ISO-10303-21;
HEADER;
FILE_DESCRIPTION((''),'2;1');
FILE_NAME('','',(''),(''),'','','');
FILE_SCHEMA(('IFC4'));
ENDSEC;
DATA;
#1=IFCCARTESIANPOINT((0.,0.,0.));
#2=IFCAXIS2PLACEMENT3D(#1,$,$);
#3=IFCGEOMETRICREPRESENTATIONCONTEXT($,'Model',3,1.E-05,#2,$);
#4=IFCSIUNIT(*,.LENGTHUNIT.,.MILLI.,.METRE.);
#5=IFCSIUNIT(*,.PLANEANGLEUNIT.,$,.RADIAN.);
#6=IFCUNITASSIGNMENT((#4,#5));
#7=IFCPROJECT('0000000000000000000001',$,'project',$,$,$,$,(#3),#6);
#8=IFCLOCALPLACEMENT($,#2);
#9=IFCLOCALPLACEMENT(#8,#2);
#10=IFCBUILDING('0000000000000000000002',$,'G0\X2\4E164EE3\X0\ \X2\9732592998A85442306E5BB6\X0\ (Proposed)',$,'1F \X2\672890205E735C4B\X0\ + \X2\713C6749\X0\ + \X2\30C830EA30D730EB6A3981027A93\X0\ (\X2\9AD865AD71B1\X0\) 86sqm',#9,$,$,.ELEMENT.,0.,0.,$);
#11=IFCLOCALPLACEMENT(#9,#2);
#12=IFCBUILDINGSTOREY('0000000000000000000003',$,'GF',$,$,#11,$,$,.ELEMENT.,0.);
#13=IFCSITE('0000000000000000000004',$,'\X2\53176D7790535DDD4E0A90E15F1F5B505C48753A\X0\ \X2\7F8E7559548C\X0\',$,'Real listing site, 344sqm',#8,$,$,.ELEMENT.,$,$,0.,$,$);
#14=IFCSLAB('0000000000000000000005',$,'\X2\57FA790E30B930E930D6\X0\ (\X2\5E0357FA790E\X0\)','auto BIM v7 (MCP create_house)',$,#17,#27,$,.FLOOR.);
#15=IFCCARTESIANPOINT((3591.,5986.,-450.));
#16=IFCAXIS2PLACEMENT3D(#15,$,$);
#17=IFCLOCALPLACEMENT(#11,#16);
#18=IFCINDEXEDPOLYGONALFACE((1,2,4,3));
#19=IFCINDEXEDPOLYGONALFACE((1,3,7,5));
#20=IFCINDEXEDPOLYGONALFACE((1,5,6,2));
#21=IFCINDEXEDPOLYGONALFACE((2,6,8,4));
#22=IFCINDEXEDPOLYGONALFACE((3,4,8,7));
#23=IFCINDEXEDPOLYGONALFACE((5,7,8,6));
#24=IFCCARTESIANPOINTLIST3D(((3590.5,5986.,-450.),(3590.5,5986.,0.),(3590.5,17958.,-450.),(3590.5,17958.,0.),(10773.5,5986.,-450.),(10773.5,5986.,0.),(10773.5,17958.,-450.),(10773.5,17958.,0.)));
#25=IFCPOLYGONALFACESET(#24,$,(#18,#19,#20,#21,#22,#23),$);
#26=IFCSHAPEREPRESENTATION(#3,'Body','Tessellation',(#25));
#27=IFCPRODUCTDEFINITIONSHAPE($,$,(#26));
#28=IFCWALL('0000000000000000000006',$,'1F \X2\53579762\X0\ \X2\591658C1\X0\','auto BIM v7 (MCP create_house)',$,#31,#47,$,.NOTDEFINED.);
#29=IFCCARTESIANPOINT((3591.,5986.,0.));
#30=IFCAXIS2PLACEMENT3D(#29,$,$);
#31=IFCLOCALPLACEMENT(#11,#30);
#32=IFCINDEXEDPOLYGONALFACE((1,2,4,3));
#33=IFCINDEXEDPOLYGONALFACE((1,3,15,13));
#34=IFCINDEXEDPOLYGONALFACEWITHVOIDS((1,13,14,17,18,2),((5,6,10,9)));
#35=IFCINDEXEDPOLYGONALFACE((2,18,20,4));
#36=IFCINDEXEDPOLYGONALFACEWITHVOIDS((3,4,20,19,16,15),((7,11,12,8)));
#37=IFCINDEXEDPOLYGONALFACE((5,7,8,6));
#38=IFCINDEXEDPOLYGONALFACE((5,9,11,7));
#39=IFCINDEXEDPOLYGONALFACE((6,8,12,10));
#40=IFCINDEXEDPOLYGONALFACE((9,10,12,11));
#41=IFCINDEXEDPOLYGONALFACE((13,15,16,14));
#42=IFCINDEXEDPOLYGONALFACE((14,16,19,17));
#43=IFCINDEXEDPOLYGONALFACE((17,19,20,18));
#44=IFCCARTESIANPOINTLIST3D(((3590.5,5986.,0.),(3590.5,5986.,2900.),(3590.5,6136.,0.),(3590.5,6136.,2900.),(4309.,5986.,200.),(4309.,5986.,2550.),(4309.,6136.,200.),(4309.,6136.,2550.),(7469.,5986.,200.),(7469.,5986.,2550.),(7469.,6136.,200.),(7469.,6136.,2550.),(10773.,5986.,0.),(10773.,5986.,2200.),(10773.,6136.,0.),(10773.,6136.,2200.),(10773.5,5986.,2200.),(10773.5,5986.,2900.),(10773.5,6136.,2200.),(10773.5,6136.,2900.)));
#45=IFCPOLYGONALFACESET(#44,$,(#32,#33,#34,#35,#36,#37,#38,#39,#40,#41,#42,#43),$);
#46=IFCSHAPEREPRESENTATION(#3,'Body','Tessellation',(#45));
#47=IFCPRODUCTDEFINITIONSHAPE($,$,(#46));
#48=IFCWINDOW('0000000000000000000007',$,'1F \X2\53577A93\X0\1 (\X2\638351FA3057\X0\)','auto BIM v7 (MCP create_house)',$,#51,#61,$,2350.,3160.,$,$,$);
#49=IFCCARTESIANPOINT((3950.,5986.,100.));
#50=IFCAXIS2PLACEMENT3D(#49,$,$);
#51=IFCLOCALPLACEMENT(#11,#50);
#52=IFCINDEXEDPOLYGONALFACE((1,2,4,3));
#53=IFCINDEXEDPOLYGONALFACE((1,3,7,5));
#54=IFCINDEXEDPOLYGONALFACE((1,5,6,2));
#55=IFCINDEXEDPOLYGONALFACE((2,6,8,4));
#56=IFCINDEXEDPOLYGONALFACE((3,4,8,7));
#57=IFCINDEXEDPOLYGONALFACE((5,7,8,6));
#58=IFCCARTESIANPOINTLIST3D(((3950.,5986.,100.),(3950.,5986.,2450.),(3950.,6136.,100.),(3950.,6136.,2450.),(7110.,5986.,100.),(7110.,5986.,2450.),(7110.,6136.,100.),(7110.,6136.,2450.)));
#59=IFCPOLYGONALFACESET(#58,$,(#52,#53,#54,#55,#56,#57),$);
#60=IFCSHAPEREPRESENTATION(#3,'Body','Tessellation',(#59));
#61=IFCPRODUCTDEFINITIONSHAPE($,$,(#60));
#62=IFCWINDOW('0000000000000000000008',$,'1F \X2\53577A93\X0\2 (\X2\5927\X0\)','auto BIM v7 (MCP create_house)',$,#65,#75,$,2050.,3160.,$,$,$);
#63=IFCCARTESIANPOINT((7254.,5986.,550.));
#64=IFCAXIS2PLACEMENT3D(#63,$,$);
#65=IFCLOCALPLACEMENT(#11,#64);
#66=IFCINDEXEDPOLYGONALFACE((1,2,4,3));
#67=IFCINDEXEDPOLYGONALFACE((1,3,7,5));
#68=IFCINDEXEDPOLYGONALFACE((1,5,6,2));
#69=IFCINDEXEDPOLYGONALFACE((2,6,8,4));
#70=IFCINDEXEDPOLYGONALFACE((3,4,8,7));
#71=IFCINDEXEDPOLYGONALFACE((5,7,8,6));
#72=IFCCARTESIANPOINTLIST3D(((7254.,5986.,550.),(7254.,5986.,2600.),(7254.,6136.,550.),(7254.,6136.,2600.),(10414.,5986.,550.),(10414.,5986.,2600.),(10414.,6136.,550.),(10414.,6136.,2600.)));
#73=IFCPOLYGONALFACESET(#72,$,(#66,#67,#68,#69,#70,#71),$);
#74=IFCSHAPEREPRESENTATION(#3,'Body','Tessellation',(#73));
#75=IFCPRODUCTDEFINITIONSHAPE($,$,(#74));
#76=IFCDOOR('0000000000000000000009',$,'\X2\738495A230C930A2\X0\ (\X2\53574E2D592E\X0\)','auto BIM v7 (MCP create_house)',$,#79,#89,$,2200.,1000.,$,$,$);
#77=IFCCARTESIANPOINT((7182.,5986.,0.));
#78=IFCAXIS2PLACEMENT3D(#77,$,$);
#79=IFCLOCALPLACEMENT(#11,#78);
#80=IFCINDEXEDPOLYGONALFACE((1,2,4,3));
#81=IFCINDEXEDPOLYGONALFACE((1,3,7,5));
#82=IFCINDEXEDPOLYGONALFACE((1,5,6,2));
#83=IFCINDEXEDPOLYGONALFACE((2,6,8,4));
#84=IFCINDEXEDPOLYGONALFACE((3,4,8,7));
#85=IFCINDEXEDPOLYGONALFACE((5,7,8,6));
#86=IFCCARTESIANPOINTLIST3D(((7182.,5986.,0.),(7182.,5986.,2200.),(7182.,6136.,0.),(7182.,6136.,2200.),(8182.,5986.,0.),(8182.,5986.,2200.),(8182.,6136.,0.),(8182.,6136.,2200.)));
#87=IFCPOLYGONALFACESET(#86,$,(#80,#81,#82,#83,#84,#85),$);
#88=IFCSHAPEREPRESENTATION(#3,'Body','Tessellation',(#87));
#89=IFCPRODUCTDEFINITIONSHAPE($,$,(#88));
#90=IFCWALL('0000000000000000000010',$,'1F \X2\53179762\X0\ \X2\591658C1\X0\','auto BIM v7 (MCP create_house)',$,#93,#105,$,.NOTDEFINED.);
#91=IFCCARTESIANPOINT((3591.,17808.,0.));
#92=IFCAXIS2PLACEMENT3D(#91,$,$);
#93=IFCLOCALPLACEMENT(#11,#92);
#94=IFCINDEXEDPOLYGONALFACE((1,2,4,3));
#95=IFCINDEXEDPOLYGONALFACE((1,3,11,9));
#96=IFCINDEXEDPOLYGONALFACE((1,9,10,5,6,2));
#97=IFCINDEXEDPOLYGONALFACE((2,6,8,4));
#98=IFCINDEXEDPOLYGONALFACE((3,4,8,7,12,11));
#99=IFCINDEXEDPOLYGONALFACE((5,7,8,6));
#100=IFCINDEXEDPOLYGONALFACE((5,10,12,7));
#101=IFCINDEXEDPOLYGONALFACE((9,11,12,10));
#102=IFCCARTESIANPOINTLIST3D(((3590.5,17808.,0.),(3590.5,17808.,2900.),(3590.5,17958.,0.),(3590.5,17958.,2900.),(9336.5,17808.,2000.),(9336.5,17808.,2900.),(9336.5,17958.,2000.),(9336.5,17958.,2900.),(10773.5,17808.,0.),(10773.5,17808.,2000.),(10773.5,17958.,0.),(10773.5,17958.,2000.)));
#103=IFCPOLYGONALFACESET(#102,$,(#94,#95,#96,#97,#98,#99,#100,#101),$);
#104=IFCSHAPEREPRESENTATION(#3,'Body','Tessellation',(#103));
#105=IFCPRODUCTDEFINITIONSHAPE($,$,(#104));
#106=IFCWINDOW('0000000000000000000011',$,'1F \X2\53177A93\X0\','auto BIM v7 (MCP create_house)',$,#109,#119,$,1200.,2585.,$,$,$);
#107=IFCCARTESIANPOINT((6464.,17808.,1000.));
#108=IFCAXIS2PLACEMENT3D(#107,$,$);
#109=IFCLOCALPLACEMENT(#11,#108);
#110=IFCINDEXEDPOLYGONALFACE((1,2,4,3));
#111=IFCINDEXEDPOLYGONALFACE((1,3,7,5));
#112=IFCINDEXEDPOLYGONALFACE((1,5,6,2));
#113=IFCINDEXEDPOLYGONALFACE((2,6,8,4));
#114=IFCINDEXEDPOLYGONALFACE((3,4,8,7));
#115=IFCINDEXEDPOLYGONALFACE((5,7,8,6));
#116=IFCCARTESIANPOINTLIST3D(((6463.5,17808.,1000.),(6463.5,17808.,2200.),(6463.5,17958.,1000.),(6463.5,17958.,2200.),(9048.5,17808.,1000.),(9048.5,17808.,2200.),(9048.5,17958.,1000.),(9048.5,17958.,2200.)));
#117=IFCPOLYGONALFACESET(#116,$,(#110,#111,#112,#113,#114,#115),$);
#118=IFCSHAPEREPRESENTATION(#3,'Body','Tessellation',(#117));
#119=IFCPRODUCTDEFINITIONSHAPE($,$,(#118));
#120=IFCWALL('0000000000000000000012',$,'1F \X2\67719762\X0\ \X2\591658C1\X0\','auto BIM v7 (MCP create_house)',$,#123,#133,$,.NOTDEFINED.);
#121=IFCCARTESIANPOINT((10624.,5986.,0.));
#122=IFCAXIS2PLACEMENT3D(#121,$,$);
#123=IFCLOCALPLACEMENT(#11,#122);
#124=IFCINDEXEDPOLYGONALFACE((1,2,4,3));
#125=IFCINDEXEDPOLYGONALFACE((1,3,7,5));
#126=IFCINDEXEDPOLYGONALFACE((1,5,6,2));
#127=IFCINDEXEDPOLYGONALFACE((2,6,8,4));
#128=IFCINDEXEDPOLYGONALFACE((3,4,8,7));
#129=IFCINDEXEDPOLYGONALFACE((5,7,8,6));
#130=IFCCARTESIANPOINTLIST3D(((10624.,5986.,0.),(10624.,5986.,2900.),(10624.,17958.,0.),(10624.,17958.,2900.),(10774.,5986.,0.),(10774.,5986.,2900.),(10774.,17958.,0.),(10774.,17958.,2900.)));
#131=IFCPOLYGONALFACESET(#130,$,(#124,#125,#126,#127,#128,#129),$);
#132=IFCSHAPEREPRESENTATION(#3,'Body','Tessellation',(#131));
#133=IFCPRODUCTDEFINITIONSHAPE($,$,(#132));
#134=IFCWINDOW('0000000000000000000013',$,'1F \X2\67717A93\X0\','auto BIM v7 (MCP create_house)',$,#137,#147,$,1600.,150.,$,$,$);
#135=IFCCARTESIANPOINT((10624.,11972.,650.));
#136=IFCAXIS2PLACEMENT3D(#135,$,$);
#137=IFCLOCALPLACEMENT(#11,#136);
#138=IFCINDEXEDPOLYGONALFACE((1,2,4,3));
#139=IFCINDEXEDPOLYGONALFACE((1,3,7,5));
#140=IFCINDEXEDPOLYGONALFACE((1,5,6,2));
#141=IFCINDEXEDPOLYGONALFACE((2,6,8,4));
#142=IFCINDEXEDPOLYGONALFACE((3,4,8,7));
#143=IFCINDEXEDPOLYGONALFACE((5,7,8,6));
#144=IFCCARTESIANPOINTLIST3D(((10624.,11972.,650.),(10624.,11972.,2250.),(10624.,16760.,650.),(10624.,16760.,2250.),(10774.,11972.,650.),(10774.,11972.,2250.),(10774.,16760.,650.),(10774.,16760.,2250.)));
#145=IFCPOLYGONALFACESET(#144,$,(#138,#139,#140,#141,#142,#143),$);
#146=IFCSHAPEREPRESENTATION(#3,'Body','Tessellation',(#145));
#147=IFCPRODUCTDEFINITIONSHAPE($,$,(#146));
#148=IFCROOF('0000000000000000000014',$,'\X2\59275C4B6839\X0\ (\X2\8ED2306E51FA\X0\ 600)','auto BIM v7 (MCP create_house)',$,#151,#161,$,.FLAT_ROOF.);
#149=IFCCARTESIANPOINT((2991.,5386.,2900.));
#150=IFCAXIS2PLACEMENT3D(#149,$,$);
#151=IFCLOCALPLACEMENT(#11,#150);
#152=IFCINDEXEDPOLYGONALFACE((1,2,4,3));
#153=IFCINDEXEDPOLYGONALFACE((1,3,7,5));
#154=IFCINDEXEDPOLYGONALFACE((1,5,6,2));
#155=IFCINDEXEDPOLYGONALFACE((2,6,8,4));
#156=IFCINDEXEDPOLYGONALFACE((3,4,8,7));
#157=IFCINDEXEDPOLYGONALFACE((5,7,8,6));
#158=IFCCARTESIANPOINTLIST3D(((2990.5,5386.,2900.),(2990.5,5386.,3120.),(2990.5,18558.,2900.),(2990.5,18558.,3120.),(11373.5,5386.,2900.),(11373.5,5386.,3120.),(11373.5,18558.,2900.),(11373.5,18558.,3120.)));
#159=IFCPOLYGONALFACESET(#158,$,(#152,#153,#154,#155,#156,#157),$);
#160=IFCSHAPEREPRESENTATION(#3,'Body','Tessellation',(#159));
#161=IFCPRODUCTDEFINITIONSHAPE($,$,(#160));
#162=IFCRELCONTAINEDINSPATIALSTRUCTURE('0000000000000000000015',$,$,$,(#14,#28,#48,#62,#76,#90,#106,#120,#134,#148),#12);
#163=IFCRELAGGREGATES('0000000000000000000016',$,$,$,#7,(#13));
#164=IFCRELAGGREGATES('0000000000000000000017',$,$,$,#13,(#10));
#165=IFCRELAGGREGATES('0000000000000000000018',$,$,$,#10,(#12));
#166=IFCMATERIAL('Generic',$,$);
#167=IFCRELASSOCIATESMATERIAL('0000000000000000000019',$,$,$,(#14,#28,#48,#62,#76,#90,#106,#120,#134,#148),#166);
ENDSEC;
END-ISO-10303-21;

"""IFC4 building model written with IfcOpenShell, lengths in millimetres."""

from ifc_helpers import new_model, si_unit, frame, frame_2d, origin, place, context, project, spatial, rectangle, extrude, material, element, fill, save


model = new_model("IFC4")

# Units and contexts
model_context = context("Model", 3, precision=1e-05, world=origin())
ifc_project = project(units=[si_unit("LENGTHUNIT", "METRE", prefix="MILLI"), si_unit("PLANEANGLEUNIT", "RADIAN")], contexts=[model_context])

# Site, building, storey
site_placement = place(None, origin())
site = spatial("IfcSite", under=ifc_project, at=site_placement, Name="北海道川上郡弟子屈町 美留和", ObjectType="Real listing site, 344sqm", CompositionType="ELEMENT", RefElevation=0.0)
building_placement = place(site_placement, origin())
building = spatial("IfcBuilding", under=site, at=building_placement, Name="G0世代 露天風呂の家 (Proposed)", ObjectType="1F 木造平屋 + 焼杉 + トリプル樹脂窓 (高断熱) 86sqm", CompositionType="ELEMENT", ElevationOfRefHeight=0.0, ElevationOfTerrain=0.0)
storey_placement = place(building_placement, origin())
storey = spatial("IfcBuildingStorey", under=building, at=storey_placement, Name="GF", CompositionType="ELEMENT", Elevation=0.0)

# Slab
ifc_material = material(Name="Generic")
slab_1_placement = place(storey_placement, frame((3591.0, 5986.0, -450.0)))
element("IfcSlab", 1, at=slab_1_placement, inside=storey, material=ifc_material, Name="基礎スラブ (布基礎)", Description="auto BIM v7 (MCP create_house)", PredefinedType="FLOOR", context=model_context, shape_type="SweptSolid", body=[
    extrude(rectangle(XDim=7183.0, YDim=11972.0, at=frame_2d((3591.0, 5986.0))), frame((3591.0, 5986.0, -450.0)), (0.0, 0.0, 1.0), 450.0),
])

# Wall, openings, windows, door
wall_1_placement = place(storey_placement, frame((3591.0, 5986.0, 0.0)))
wall_1 = element("IfcWall", 2, at=wall_1_placement, inside=storey, material=ifc_material, Name="1F 南面 外壁", Description="auto BIM v7 (MCP create_house)", PredefinedType="NOTDEFINED", context=model_context, shape_type="SweptSolid", body=[
    extrude(rectangle(XDim=7183.0, YDim=150.0, at=frame_2d((3591.0, 75.0))), frame((3591.0, 5986.0, 0.0)), (0.0, 0.0, 1.0), 2900.0),
])
opening_1_placement = place(storey_placement, frame((3950.0, 5986.0, 100.0)))
opening_1 = element("IfcOpeningElement", 3, at=opening_1_placement, cuts=wall_1, PredefinedType="NOTDEFINED", context=model_context, shape_type="SweptSolid", body=[
    extrude(rectangle(XDim=3160.0, YDim=150.0, at=frame_2d((1580.0, 75.0))), frame((3950.0, 5986.0, 100.0)), (0.0, 0.0, 1.0), 2350.0),
])
opening_2_placement = place(storey_placement, frame((7254.0, 5986.0, 550.0)))
opening_2 = element("IfcOpeningElement", 4, at=opening_2_placement, cuts=wall_1, PredefinedType="NOTDEFINED", context=model_context, shape_type="SweptSolid", body=[
    extrude(rectangle(XDim=3160.0, YDim=150.0, at=frame_2d((1580.0, 75.0))), frame((7254.0, 5986.0, 550.0)), (0.0, 0.0, 1.0), 2050.0),
])
opening_3_placement = place(storey_placement, frame((7182.0, 5986.0, 0.0)))
opening_3 = element("IfcOpeningElement", 5, at=opening_3_placement, cuts=wall_1, PredefinedType="NOTDEFINED", context=model_context, shape_type="SweptSolid", body=[
    extrude(rectangle(XDim=1000.0, YDim=150.0, at=frame_2d((500.0, 75.0))), frame((7182.0, 5986.0, 0.0)), (0.0, 0.0, 1.0), 2200.0),
])
window_1_placement = place(storey_placement, frame((3950.0, 5986.0, 100.0)))
window_1 = element("IfcWindow", 6, at=window_1_placement, inside=storey, material=ifc_material, Name="1F 南窓1 (掃出し)", Description="auto BIM v7 (MCP create_house)", OverallHeight=2350.0, OverallWidth=3160.0, context=model_context, shape_type="SweptSolid", body=[
    extrude(rectangle(XDim=3160.0, YDim=150.0, at=frame_2d((1580.0, 75.0))), frame((3950.0, 5986.0, 100.0)), (0.0, 0.0, 1.0), 2350.0),
])
fill(opening_1, window_1)
window_2_placement = place(storey_placement, frame((7254.0, 5986.0, 550.0)))
window_2 = element("IfcWindow", 7, at=window_2_placement, inside=storey, material=ifc_material, Name="1F 南窓2 (大)", Description="auto BIM v7 (MCP create_house)", OverallHeight=2050.0, OverallWidth=3160.0, context=model_context, shape_type="SweptSolid", body=[
    extrude(rectangle(XDim=3160.0, YDim=150.0, at=frame_2d((1580.0, 75.0))), frame((7254.0, 5986.0, 550.0)), (0.0, 0.0, 1.0), 2050.0),
])
fill(opening_2, window_2)
door_placement = place(storey_placement, frame((7182.0, 5986.0, 0.0)))
door = element("IfcDoor", 8, at=door_placement, inside=storey, material=ifc_material, Name="玄関ドア (南中央)", Description="auto BIM v7 (MCP create_house)", OverallHeight=2200.0, OverallWidth=1000.0, context=model_context, shape_type="SweptSolid", body=[
    extrude(rectangle(XDim=1000.0, YDim=150.0, at=frame_2d((500.0, 75.0))), frame((7182.0, 5986.0, 0.0)), (0.0, 0.0, 1.0), 2200.0),
])
fill(opening_3, door)

# Walls, openings, windows
wall_2_placement = place(storey_placement, frame((3591.0, 17808.0, 0.0)))
wall_2 = element("IfcWall", 9, at=wall_2_placement, inside=storey, material=ifc_material, Name="1F 北面 外壁", Description="auto BIM v7 (MCP create_house)", PredefinedType="NOTDEFINED", context=model_context, shape_type="SweptSolid", body=[
    extrude(rectangle(XDim=7183.0, YDim=150.0, at=frame_2d((3591.0, 75.0))), frame((3591.0, 17808.0, 0.0)), (0.0, 0.0, 1.0), 2900.0),
])
opening_4_placement = place(storey_placement, frame((6464.0, 17808.0, 1000.0)))
opening_4 = element("IfcOpeningElement", 10, at=opening_4_placement, cuts=wall_2, PredefinedType="NOTDEFINED", context=model_context, shape_type="SweptSolid", body=[
    extrude(rectangle(XDim=2585.0, YDim=150.0, at=frame_2d((1292.0, 75.0))), frame((6464.0, 17808.0, 1000.0)), (0.0, 0.0, 1.0), 1200.0),
])
window_3_placement = place(storey_placement, frame((6464.0, 17808.0, 1000.0)))
window_3 = element("IfcWindow", 11, at=window_3_placement, inside=storey, material=ifc_material, Name="1F 北窓", Description="auto BIM v7 (MCP create_house)", OverallHeight=1200.0, OverallWidth=2585.0, context=model_context, shape_type="SweptSolid", body=[
    extrude(rectangle(XDim=2585.0, YDim=150.0, at=frame_2d((1292.0, 75.0))), frame((6464.0, 17808.0, 1000.0)), (0.0, 0.0, 1.0), 1200.0),
])
fill(opening_4, window_3)
wall_3_placement = place(storey_placement, frame((10624.0, 5986.0, 0.0)))
wall_3 = element("IfcWall", 12, at=wall_3_placement, inside=storey, material=ifc_material, Name="1F 東面 外壁", Description="auto BIM v7 (MCP create_house)", PredefinedType="NOTDEFINED", context=model_context, shape_type="SweptSolid", body=[
    extrude(rectangle(XDim=150.0, YDim=11972.0, at=frame_2d((75.0, 5986.0))), frame((10624.0, 5986.0, 0.0)), (0.0, 0.0, 1.0), 2900.0),
])
opening_5_placement = place(storey_placement, frame((10624.0, 11972.0, 650.0)))
opening_5 = element("IfcOpeningElement", 13, at=opening_5_placement, cuts=wall_3, PredefinedType="NOTDEFINED", context=model_context, shape_type="SweptSolid", body=[
    extrude(rectangle(XDim=150.0, YDim=4788.0, at=frame_2d((75.0, 2394.0))), frame((10624.0, 11972.0, 650.0)), (0.0, 0.0, 1.0), 1600.0),
])
window_4_placement = place(storey_placement, frame((10624.0, 11972.0, 650.0)))
window_4 = element("IfcWindow", 14, at=window_4_placement, inside=storey, material=ifc_material, Name="1F 東窓", Description="auto BIM v7 (MCP create_house)", OverallHeight=1600.0, OverallWidth=150.0, context=model_context, shape_type="SweptSolid", body=[
    extrude(rectangle(XDim=150.0, YDim=4788.0, at=frame_2d((75.0, 2394.0))), frame((10624.0, 11972.0, 650.0)), (0.0, 0.0, 1.0), 1600.0),
])
fill(opening_5, window_4)

# Roof
roof_1_placement = place(storey_placement, frame((2991.0, 5386.0, 2900.0)))
element("IfcRoof", 15, at=roof_1_placement, inside=storey, material=ifc_material, Name="大屋根 (軒の出 600)", Description="auto BIM v7 (MCP create_house)", PredefinedType="FLAT_ROOF", context=model_context, shape_type="SweptSolid", body=[
    extrude(rectangle(XDim=8383.0, YDim=13172.0, at=frame_2d((4191.0, 6586.0))), frame((2991.0, 5386.0, 2900.0)), (0.0, 0.0, 1.0), 220.0),
])

save(model, "model.ifc")
